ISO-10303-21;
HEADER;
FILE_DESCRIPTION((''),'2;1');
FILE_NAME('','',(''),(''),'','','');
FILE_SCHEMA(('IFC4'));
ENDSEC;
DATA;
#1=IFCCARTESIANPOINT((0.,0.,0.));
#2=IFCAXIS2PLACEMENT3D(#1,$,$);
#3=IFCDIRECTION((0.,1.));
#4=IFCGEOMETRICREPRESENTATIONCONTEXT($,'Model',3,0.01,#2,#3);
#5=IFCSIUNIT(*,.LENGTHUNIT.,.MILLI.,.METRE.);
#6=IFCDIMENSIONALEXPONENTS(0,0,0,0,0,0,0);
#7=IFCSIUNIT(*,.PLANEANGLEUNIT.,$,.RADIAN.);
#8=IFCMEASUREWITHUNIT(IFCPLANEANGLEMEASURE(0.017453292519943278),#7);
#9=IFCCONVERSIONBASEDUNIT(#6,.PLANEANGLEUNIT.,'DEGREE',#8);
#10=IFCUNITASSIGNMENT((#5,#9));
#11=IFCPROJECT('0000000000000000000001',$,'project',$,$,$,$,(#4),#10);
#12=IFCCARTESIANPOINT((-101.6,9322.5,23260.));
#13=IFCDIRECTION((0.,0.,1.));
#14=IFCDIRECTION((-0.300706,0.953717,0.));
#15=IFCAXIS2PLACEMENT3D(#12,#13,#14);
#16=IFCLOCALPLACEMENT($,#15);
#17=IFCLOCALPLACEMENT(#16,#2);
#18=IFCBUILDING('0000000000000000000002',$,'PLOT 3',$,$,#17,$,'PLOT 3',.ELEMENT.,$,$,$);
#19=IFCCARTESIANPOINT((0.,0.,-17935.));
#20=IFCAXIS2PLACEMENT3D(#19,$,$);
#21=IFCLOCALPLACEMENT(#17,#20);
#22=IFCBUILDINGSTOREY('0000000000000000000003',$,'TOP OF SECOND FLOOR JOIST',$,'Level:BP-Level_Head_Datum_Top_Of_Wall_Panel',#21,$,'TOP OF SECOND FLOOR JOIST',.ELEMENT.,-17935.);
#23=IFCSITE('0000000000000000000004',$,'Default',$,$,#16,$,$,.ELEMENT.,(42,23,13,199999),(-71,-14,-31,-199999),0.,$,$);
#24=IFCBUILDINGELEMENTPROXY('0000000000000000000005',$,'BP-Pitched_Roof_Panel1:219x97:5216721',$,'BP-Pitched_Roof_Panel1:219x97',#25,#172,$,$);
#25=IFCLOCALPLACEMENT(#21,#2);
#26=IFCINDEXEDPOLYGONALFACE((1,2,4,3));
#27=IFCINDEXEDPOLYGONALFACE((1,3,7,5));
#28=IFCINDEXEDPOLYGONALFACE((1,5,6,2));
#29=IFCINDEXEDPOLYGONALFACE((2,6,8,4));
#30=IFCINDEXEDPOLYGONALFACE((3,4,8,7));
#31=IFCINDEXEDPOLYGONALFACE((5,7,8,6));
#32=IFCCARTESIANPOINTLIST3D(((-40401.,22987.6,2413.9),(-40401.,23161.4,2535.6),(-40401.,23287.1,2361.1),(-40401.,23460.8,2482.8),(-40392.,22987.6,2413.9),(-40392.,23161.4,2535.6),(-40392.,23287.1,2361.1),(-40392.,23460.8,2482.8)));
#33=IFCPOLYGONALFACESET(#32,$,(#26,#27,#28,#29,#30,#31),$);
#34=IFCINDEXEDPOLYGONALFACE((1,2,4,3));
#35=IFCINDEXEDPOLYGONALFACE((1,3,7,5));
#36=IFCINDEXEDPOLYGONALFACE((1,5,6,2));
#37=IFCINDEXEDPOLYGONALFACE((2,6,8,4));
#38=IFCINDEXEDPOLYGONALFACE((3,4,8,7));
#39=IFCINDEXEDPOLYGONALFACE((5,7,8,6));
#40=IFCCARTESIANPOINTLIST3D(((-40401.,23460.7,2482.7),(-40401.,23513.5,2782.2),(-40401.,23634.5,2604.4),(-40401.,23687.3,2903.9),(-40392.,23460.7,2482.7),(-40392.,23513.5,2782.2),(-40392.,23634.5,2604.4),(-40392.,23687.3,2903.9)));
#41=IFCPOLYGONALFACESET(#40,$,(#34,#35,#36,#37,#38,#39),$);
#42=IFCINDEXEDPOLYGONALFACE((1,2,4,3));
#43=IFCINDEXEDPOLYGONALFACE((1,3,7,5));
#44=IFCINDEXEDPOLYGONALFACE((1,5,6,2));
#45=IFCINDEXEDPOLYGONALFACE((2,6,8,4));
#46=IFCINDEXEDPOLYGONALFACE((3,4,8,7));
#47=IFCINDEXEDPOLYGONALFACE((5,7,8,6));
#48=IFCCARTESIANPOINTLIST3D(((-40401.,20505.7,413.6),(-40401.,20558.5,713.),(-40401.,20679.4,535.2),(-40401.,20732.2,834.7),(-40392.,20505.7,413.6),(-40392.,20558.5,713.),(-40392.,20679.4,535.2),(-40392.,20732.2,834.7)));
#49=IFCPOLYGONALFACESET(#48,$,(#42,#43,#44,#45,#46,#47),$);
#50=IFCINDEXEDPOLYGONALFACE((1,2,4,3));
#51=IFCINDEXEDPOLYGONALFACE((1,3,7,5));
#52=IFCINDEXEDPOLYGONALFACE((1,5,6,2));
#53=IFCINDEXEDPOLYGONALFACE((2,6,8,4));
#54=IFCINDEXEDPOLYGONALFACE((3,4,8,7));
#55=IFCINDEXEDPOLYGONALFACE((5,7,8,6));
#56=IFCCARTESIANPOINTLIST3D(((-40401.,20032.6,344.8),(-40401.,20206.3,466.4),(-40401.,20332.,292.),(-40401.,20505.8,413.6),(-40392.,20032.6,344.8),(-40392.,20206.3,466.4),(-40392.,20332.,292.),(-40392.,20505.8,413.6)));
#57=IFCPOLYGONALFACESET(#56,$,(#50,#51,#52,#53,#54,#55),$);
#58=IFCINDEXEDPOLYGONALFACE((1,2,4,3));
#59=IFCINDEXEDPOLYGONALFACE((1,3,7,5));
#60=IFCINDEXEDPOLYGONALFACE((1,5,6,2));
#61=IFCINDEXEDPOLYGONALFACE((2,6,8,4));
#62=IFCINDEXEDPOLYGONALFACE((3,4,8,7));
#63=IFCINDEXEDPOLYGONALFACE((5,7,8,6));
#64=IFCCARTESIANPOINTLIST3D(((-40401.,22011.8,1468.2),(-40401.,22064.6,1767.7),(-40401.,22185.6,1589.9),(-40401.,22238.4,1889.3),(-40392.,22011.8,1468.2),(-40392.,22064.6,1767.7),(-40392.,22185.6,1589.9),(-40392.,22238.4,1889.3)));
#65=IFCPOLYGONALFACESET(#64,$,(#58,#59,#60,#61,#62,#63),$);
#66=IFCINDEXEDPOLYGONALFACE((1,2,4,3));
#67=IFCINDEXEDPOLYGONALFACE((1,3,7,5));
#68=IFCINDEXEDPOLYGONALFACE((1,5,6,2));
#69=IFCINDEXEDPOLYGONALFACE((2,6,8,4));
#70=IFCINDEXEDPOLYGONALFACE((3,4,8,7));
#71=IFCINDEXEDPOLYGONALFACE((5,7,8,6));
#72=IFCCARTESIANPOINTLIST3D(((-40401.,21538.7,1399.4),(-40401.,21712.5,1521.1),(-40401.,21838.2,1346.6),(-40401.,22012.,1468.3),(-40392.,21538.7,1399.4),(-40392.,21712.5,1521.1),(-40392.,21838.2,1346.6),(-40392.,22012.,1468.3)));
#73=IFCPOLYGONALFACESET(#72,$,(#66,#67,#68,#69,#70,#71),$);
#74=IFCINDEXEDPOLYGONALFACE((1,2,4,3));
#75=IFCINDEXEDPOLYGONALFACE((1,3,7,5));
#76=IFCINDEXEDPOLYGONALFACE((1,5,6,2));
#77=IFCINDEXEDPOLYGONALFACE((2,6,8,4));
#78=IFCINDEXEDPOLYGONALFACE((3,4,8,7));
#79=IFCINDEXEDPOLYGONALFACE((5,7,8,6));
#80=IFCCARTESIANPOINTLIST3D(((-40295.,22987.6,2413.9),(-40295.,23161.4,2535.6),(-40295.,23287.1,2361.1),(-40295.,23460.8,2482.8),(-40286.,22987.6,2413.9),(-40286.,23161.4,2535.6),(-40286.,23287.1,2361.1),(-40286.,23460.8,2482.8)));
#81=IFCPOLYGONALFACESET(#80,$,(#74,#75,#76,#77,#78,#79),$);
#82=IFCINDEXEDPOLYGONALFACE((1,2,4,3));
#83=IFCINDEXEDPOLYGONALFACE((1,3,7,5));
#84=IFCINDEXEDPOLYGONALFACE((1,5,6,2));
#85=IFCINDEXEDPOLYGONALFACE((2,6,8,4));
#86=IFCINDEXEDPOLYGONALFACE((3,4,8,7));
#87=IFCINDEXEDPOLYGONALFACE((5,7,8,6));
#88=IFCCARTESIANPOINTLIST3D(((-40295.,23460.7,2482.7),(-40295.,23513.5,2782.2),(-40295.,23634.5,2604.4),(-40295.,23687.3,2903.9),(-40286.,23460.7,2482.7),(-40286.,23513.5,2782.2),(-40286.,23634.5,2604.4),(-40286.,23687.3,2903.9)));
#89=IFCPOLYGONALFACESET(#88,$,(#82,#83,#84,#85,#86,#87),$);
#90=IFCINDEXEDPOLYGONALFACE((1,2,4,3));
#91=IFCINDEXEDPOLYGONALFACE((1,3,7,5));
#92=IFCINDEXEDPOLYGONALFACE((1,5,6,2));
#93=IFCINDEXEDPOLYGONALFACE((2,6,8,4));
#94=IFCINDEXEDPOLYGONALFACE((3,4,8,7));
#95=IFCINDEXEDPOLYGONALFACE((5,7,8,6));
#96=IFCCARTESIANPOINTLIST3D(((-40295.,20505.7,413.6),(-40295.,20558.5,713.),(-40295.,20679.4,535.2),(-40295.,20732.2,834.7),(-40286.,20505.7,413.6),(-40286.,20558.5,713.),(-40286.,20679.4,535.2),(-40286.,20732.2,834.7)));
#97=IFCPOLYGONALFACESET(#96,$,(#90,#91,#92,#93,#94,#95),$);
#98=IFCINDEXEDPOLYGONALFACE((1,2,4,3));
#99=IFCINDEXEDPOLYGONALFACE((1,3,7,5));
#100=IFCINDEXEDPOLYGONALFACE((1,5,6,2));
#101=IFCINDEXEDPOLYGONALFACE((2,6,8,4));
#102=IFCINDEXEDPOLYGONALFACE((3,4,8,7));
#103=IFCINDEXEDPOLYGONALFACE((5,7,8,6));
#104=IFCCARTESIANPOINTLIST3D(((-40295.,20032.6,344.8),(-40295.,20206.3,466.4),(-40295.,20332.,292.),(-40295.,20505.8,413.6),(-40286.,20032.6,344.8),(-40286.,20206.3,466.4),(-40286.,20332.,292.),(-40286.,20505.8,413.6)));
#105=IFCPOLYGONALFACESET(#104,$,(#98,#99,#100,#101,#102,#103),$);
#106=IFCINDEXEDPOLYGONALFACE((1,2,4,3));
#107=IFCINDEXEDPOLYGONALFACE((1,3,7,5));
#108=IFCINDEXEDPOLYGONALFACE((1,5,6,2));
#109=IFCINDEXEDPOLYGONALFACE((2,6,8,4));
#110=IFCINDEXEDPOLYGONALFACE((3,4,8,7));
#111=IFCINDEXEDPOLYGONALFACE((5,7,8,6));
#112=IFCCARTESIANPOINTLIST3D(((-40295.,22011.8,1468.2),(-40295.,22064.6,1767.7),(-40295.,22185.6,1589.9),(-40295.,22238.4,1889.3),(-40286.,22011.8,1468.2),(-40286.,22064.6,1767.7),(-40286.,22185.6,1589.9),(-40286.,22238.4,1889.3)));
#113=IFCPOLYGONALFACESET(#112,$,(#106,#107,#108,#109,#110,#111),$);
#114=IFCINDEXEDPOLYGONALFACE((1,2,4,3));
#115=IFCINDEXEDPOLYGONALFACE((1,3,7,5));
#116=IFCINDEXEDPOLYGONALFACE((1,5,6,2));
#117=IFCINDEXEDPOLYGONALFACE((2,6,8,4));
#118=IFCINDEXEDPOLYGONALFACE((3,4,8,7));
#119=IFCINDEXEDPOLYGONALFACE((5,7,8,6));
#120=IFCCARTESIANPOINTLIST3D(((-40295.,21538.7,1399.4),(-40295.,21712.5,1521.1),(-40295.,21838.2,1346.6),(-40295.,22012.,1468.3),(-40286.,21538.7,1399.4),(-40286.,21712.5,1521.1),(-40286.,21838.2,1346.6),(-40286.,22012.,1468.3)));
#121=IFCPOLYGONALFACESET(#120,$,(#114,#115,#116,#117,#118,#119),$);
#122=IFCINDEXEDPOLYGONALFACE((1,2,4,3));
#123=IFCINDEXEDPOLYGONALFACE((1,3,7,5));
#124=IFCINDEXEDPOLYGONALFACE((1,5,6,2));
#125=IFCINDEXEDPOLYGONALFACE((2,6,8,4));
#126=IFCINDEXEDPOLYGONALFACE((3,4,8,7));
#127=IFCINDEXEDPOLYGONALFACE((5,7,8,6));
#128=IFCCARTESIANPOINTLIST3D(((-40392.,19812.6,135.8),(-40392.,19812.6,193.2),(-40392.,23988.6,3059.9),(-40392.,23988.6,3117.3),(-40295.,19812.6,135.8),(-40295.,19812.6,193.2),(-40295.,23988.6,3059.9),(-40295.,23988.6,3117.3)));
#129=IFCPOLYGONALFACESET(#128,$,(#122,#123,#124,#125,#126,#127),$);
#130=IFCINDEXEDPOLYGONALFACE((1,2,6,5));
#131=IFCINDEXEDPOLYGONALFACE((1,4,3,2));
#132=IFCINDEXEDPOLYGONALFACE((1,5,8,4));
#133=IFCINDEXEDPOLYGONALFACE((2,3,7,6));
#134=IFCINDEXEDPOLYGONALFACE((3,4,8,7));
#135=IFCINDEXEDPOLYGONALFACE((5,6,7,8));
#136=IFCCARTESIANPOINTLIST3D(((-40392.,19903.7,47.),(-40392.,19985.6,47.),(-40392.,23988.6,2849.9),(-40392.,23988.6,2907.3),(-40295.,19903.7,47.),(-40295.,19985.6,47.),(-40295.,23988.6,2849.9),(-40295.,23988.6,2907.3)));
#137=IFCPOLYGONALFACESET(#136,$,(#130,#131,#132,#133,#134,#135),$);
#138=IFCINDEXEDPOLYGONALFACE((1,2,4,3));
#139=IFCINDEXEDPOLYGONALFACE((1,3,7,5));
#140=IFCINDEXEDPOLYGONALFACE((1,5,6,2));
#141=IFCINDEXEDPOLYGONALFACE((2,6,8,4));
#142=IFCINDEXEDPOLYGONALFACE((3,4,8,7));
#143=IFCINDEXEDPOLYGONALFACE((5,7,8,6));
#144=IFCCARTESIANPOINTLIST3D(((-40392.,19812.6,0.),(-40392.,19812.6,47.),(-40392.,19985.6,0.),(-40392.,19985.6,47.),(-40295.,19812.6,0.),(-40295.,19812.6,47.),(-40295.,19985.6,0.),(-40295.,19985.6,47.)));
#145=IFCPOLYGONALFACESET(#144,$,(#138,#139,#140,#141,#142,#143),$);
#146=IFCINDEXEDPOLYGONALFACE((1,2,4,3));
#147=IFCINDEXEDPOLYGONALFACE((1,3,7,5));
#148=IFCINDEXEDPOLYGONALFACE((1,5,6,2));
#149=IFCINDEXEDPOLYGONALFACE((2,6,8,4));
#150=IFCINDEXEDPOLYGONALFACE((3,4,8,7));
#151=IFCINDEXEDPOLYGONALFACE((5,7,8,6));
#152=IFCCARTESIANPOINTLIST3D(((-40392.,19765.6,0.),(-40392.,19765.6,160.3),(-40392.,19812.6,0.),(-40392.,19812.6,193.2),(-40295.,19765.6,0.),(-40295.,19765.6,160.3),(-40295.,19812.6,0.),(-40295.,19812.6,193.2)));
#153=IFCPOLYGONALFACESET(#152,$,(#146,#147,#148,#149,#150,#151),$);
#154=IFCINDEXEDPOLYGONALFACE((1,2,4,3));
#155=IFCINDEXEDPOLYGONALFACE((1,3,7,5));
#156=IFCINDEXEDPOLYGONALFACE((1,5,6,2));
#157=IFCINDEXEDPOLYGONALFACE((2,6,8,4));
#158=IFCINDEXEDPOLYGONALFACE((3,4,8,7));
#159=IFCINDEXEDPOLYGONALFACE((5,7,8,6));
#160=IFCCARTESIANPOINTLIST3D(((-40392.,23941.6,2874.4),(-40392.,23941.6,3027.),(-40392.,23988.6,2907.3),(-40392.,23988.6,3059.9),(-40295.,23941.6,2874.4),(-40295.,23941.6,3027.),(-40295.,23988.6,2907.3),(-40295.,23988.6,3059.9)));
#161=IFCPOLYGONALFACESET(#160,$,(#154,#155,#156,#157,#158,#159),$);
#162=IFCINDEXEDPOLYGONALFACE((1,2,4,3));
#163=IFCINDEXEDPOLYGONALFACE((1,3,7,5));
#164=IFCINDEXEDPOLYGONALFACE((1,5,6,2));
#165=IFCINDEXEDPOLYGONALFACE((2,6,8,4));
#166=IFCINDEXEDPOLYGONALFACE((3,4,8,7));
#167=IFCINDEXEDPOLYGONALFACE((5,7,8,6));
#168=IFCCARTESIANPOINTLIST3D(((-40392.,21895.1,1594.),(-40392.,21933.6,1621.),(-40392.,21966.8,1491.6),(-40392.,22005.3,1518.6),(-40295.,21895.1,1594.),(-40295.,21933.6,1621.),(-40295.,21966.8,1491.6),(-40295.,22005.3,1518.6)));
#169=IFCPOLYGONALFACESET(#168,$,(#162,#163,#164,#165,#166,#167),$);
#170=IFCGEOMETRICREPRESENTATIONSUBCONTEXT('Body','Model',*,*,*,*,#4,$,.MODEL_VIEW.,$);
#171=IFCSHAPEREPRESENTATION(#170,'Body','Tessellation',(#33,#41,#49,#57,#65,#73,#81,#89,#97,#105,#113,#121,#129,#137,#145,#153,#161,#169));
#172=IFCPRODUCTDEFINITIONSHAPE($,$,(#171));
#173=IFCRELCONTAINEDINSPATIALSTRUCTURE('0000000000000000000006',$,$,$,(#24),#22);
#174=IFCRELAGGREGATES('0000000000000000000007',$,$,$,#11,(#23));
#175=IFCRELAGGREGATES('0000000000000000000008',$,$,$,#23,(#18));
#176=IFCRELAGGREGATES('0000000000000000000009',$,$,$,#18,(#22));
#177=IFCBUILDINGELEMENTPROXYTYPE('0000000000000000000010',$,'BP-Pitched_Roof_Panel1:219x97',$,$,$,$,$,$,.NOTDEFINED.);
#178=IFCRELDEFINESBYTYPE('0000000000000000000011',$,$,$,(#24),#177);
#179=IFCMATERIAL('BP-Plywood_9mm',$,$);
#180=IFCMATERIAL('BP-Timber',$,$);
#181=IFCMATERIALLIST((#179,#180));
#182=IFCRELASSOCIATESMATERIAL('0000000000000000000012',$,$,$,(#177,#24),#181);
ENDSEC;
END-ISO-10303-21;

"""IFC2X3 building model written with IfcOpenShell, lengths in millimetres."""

from ifc_helpers import new_model, entity, si_unit, converted_unit, direction, frame, frame_2d, origin, origin_2d_with_axis, place, context, subcontext, project, spatial, polyline, rectangle, outline, extrude, source, transform, mapped, material, material_list, type_object, type_shapes, element, save


model = new_model("IFC2X3")

# Units and contexts
model_context = context("Model", 3, precision=0.01, world=origin(), true_north=direction((0.0, 1.0)))
body_context = subcontext(model_context, "Body", "Model", "MODEL_VIEW")
ifc_project = project(units=[si_unit("LENGTHUNIT", "METRE", prefix="MILLI"), converted_unit("PLANEANGLEUNIT", "DEGREE", entity("IfcPlaneAngleMeasure", 0.017453292519943278), si_unit("PLANEANGLEUNIT", "RADIAN"), dimensions=[0, 0, 0, 0, 0, 0, 0])], contexts=[model_context])

# Site, building, storey
site_placement = place(None, frame((-101.6, 9322.5, 23260.0), z_axis=(0.0, 0.0, 1.0), x_axis=(-0.300706, 0.953717, 0.0)))
site = spatial("IfcSite", under=ifc_project, at=site_placement, Name="Default", CompositionType="ELEMENT", RefLatitude=(42, 23, 13, 199999), RefLongitude=(-71, -14, -31, -199999), RefElevation=0.0)
building_placement = place(site_placement, origin())
building = spatial("IfcBuilding", under=site, at=building_placement, Name="PLOT 3", LongName="PLOT 3", CompositionType="ELEMENT")
storey_placement = place(building_placement, frame((0.0, 0.0, -17935.0)))
storey = spatial("IfcBuildingStorey", under=building, at=storey_placement, Name="TOP OF SECOND FLOOR JOIST", ObjectType="Level:BP-Level_Head_Datum_Top_Of_Wall_Panel", LongName="TOP OF SECOND FLOOR JOIST", CompositionType="ELEMENT", Elevation=-17935.0)

# Building element proxy
ifc_material_1 = material(Name="BP-Timber")
ifc_material_2 = material(Name="BP-Plywood_9mm")
ifc_material_list = material_list([ifc_material_2, ifc_material_1])
building_element_proxy_type_1 = type_object("IfcBuildingElementProxyType", Name="BP-Pitched_Roof_Panel1:219x97", PredefinedType="NOTDEFINED", material=ifc_material_list)
shared_shape_1 = source(origin(), body_context, "Body", "SweptSolid", [
    extrude(outline(polyline([(-77.0, -75.0), (227.0, -75.0), (77.0, 75.0), (-227.0, 75.0), (-77.0, -75.0)])), frame((36.3, 3947.0, 2448.4), z_axis=(0.0, 1.0, 0.0), x_axis=(-0.984808, 0.0, 0.173648)), (0.0, 0.0, 1.0), 9.0),
    extrude(outline(polyline([(1.4, -107.5), (213.6, -107.5), (-1.4, 107.5), (-213.6, 107.5), (1.4, -107.5)])), frame((386.1, 3947.0, 2693.3), z_axis=(0.0, 1.0, 0.0), x_axis=(-0.819152, 0.0, -0.573576)), (0.0, 0.0, 1.0), 9.0),
    extrude(outline(polyline([(1.4, -107.5), (213.6, -107.5), (-1.4, 107.5), (-213.6, 107.5), (1.4, -107.5)])), frame((-2569.0, 3947.0, 624.1), z_axis=(0.0, 1.0, 0.0), x_axis=(-0.819152, 0.0, -0.573576)), (0.0, 0.0, 1.0), 9.0),
    extrude(outline(polyline([(-77.0, -75.0), (227.0, -75.0), (77.0, 75.0), (-227.0, 75.0), (-77.0, -75.0)])), frame((-2918.8, 3947.0, 379.2), z_axis=(0.0, 1.0, 0.0), x_axis=(-0.984808, 0.0, 0.173648)), (0.0, 0.0, 1.0), 9.0),
    extrude(outline(polyline([(1.4, -107.5), (213.6, -107.5), (-1.4, 107.5), (-213.6, 107.5), (1.4, -107.5)])), frame((-1062.8, 3947.0, 1678.8), z_axis=(0.0, 1.0, 0.0), x_axis=(-0.819152, 0.0, -0.573576)), (0.0, 0.0, 1.0), 9.0),
    extrude(outline(polyline([(-77.0, -75.0), (227.0, -75.0), (77.0, 75.0), (-227.0, 75.0), (-77.0, -75.0)])), frame((-1412.6, 3947.0, 1433.9), z_axis=(0.0, 1.0, 0.0), x_axis=(-0.984808, 0.0, 0.173648)), (0.0, 0.0, 1.0), 9.0),
    extrude(outline(polyline([(-77.0, -75.0), (227.0, -75.0), (77.0, 75.0), (-227.0, 75.0), (-77.0, -75.0)])), frame((36.3, 3841.0, 2448.4), z_axis=(0.0, 1.0, 0.0), x_axis=(-0.984808, 0.0, 0.173648)), (0.0, 0.0, 1.0), 9.0),
    extrude(outline(polyline([(1.4, -107.5), (213.6, -107.5), (-1.4, 107.5), (-213.6, 107.5), (1.4, -107.5)])), frame((386.1, 3841.0, 2693.3), z_axis=(0.0, 1.0, 0.0), x_axis=(-0.819152, 0.0, -0.573576)), (0.0, 0.0, 1.0), 9.0),
    extrude(outline(polyline([(1.4, -107.5), (213.6, -107.5), (-1.4, 107.5), (-213.6, 107.5), (1.4, -107.5)])), frame((-2569.0, 3841.0, 624.1), z_axis=(0.0, 1.0, 0.0), x_axis=(-0.819152, 0.0, -0.573576)), (0.0, 0.0, 1.0), 9.0),
    extrude(outline(polyline([(-77.0, -75.0), (227.0, -75.0), (77.0, 75.0), (-227.0, 75.0), (-77.0, -75.0)])), frame((-2918.8, 3841.0, 379.2), z_axis=(0.0, 1.0, 0.0), x_axis=(-0.984808, 0.0, 0.173648)), (0.0, 0.0, 1.0), 9.0),
    extrude(outline(polyline([(1.4, -107.5), (213.6, -107.5), (-1.4, 107.5), (-213.6, 107.5), (1.4, -107.5)])), frame((-1062.8, 3841.0, 1678.8), z_axis=(0.0, 1.0, 0.0), x_axis=(-0.819152, 0.0, -0.573576)), (0.0, 0.0, 1.0), 9.0),
    extrude(outline(polyline([(-77.0, -75.0), (227.0, -75.0), (77.0, 75.0), (-227.0, 75.0), (-77.0, -75.0)])), frame((-1412.6, 3841.0, 1433.9), z_axis=(0.0, 1.0, 0.0), x_axis=(-0.984808, 0.0, 0.173648)), (0.0, 0.0, 1.0), 9.0),
    extrude(outline(polyline([(-1490.7, -2088.0), (-1433.3, -2088.0), (1490.7, 2088.0), (1433.3, 2088.0), (-1490.7, -2088.0)])), frame((-1287.3, 3850.0, 1626.6), z_axis=(0.0, 1.0, 0.0), x_axis=(0.0, 0.0, -1.0)), (0.0, 0.0, 1.0), 97.0),
    extrude(outline(polyline([(-1444.5, -2022.0), (-1387.1, -2022.0), (1415.8, 1981.0), (1415.8, 2063.0), (-1444.5, -2022.0)])), frame((-1221.3, 3850.0, 1462.8), z_axis=(0.0, 1.0, 0.0), x_axis=(0.0, 0.0, -1.0)), (0.0, 0.0, 1.0), 97.0),
    extrude(rectangle(XDim=97.0, YDim=173.0, at=origin_2d_with_axis()), frame((-3288.8, 3898.5, 0.0), z_axis=(0.0, 0.0, 1.0), x_axis=(0.0, 1.0, 0.0)), (0.0, 0.0, 1.0), 47.0),
    extrude(outline(polyline([(22.0, -72.4), (79.4, -72.4), (-31.4, 85.9), (-69.9, 58.9), (22.0, -72.4)])), frame((-3398.8, 3850.0, 88.4), z_axis=(0.0, 1.0, 0.0), x_axis=(0.819152, 0.0, 0.573576)), (0.0, 0.0, 1.0), 97.0),
    extrude(outline(polyline([(15.1, -62.5), (72.5, -62.5), (-15.1, 62.5), (-72.5, 62.5), (15.1, -62.5)])), frame((777.2, 3850.0, 2967.2), z_axis=(0.0, 1.0, 0.0), x_axis=(0.819152, 0.0, 0.573576)), (0.0, 0.0, 1.0), 97.0),
    extrude(rectangle(XDim=47.0, YDim=97.0, at=frame_2d((0.0, 0.0), x_axis=(0.0, 1.0))), frame((-1201.9, 3898.5, 1505.1), z_axis=(-0.573576, 0.0, 0.819152), x_axis=(0.0, 1.0, 0.0)), (0.0, 0.0, 1.0), 125.0),
])
type_shapes(building_element_proxy_type_1, [shared_shape_1])
for number, where, z_axis, x_axis, name in (
    (1, (-36445.0, 23187.9, 0.0), (0.0, 0.0, 1.0), (0.0, 1.0, 0.0), "BP-Pitched_Roof_Panel1:219x97:5216721"),
):
    element("IfcBuildingElementProxy", number, at=place(storey_placement, frame(where, z_axis=z_axis, x_axis=x_axis)), inside=storey, type_object=building_element_proxy_type_1, material=ifc_material_list, Name=name, ObjectType="BP-Pitched_Roof_Panel1:219x97", context=body_context, shape_type="MappedRepresentation", body=[
        mapped(shared_shape_1, transform((0.0, 0.0, 0.0), scale=1.0)),
    ])

save(model, "model.ifc")
